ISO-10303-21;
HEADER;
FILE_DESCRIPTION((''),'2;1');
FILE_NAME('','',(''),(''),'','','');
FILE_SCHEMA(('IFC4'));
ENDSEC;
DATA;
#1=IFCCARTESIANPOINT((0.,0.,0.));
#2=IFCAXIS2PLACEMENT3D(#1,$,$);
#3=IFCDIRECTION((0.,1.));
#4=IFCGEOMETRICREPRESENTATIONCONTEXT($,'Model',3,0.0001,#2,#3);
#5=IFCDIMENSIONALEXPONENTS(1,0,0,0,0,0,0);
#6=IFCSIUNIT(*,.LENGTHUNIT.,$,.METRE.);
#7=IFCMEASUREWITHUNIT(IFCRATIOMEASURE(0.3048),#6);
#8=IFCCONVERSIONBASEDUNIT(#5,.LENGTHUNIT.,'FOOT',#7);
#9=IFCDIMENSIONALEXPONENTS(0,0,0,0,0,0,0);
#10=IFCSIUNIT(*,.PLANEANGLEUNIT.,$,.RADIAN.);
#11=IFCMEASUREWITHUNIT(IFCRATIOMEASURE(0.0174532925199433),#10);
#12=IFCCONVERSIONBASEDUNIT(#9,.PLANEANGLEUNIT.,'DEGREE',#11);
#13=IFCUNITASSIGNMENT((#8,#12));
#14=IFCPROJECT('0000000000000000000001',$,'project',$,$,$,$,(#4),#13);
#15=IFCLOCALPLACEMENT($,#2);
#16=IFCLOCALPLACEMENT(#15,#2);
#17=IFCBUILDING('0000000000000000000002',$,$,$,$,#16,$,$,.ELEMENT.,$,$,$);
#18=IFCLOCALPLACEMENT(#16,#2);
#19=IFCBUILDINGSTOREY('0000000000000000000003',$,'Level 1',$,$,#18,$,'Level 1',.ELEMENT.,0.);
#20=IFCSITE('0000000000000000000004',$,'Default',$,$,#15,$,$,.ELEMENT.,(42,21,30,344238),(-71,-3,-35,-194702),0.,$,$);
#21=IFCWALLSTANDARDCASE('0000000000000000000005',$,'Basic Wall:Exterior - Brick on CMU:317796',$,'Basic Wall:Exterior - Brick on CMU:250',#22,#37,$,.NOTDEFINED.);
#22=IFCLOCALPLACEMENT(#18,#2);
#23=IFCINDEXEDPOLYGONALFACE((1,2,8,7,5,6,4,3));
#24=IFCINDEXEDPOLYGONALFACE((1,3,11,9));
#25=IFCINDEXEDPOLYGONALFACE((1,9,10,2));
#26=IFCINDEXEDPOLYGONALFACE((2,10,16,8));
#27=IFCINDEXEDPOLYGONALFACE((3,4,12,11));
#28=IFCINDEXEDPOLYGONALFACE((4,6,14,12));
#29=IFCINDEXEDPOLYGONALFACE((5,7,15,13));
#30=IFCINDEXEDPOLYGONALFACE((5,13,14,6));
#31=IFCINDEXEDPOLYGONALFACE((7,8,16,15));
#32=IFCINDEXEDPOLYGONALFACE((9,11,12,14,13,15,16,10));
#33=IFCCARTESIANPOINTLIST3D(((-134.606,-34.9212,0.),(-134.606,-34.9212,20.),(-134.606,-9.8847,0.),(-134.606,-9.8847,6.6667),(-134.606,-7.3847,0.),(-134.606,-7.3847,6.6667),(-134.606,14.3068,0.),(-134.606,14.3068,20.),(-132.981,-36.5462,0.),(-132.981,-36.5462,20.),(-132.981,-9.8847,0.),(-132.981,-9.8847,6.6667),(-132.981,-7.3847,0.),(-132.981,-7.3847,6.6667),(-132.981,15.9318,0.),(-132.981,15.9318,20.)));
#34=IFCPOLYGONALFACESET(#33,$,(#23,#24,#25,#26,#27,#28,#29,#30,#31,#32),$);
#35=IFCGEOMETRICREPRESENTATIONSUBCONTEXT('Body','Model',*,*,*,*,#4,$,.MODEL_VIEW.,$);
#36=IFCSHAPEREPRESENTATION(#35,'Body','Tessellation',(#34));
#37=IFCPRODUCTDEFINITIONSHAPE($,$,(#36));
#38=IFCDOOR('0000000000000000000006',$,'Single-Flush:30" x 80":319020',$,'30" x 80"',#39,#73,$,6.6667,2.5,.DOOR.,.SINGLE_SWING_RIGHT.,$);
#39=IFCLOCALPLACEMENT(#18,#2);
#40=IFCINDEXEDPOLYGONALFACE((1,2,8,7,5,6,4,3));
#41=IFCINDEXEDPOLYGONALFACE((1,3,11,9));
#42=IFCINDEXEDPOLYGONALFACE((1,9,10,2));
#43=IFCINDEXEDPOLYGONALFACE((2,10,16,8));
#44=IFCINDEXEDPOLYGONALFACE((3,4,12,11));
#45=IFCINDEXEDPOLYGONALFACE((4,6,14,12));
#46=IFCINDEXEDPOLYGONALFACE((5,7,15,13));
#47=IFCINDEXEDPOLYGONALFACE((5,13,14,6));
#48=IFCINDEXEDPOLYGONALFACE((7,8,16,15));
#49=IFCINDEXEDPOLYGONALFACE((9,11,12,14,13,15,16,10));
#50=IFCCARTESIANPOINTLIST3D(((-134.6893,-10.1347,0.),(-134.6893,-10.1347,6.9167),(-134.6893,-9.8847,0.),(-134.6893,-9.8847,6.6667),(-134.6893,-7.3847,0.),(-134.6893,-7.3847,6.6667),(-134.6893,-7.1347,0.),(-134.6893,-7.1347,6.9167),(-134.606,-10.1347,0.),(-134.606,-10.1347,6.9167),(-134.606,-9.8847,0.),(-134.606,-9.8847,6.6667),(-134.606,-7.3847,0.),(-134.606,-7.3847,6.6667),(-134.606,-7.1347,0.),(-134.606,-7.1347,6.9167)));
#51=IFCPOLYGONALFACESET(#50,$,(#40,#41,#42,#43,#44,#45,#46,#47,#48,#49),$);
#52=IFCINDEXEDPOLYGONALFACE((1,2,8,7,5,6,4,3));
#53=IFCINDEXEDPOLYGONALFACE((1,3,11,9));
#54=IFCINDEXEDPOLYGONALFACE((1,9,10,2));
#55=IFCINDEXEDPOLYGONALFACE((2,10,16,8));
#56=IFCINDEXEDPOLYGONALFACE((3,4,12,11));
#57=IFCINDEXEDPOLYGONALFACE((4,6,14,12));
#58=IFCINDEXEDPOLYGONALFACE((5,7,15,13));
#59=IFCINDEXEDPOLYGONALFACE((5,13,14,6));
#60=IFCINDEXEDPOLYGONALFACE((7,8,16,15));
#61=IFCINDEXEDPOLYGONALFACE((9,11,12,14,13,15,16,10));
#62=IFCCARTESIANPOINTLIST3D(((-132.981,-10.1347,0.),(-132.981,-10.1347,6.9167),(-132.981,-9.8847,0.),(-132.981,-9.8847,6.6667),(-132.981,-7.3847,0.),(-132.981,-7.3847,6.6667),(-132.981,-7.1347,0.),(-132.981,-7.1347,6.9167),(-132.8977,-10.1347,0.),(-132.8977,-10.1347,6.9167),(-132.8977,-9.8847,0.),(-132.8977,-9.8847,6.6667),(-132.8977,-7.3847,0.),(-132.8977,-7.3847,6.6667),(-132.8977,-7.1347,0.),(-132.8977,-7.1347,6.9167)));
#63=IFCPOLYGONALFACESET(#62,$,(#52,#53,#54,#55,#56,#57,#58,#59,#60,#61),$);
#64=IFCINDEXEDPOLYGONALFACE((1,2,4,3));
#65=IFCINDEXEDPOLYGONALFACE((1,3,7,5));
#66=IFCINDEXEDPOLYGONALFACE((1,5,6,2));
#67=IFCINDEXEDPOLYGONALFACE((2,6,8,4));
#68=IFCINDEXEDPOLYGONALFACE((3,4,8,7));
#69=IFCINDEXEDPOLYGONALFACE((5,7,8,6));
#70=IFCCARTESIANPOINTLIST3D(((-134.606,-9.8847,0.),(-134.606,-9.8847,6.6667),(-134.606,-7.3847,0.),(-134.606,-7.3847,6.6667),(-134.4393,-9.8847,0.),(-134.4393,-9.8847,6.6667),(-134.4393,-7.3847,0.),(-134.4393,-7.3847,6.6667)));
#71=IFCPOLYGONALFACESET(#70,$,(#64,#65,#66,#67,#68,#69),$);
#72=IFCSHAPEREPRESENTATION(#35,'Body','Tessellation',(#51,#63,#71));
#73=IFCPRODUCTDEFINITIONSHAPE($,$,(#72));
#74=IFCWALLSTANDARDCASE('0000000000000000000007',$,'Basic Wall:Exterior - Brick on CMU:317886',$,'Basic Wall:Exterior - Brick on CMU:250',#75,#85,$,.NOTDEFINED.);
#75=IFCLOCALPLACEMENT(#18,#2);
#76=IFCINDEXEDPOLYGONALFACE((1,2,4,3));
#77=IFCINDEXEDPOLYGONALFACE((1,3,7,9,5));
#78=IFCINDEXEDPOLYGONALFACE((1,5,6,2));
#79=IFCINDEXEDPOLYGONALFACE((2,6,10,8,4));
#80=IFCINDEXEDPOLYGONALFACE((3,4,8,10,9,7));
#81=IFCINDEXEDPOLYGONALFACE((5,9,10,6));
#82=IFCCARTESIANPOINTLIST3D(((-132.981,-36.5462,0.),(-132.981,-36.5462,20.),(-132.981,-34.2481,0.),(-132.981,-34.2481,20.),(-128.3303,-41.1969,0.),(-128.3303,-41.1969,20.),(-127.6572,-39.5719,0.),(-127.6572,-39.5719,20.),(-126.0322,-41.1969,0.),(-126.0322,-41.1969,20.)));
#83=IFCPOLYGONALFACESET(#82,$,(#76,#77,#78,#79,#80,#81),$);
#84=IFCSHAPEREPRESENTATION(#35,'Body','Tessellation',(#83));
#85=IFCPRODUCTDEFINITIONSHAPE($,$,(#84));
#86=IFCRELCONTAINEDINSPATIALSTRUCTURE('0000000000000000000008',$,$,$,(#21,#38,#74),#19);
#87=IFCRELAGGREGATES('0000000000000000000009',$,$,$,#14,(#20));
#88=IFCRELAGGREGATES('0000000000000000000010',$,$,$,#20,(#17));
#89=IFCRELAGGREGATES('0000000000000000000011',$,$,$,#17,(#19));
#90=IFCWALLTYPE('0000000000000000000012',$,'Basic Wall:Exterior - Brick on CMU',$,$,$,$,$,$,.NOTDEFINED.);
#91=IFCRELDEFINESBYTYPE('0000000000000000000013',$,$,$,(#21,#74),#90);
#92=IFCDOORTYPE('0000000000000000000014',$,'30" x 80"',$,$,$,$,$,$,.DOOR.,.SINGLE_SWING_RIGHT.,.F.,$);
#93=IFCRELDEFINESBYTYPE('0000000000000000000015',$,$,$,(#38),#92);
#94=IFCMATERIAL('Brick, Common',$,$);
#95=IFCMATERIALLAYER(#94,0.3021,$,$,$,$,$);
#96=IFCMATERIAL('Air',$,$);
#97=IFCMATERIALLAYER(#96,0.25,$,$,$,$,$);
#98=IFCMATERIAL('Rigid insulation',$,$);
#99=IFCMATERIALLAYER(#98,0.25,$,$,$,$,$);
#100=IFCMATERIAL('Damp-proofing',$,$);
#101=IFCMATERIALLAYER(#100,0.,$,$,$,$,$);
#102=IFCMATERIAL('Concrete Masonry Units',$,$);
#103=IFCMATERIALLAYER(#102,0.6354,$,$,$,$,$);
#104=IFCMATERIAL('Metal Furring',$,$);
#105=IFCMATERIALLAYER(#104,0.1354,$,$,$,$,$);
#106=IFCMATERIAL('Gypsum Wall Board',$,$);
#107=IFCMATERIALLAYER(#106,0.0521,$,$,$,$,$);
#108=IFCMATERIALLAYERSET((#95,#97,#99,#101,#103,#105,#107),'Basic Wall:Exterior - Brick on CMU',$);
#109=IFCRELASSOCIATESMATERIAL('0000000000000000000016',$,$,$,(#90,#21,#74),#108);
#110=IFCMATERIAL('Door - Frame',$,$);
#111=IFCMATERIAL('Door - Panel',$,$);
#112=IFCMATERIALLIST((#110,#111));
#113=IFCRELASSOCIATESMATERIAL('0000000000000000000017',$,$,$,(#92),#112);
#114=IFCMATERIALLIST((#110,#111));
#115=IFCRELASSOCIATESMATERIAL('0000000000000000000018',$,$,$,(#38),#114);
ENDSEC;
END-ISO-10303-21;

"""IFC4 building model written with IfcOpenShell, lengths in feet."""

from ifc_helpers import new_model, entity, si_unit, converted_unit, direction, frame, frame_2d, origin, place, context, subcontext, project, spatial, polyline, rectangle, outline, extrude, source, transform, mapped, material, material_list, layer, layer_set, layer_usage, type_object, type_shapes, element, fill, save


model = new_model("IFC4")

# Units and contexts
model_context = context("Model", 3, precision=0.0001, world=origin(), true_north=direction((0.0, 1.0)))
body_context = subcontext(model_context, "Body", "Model", "MODEL_VIEW")
ifc_project = project(units=[converted_unit("LENGTHUNIT", "FOOT", entity("IfcRatioMeasure", 0.3048), si_unit("LENGTHUNIT", "METRE"), dimensions=[1, 0, 0, 0, 0, 0, 0]), converted_unit("PLANEANGLEUNIT", "DEGREE", entity("IfcRatioMeasure", 0.0174532925199433), si_unit("PLANEANGLEUNIT", "RADIAN"), dimensions=[0, 0, 0, 0, 0, 0, 0])], contexts=[model_context])

# Site, building, storey
site_placement = place(None, origin())
site = spatial("IfcSite", under=ifc_project, at=site_placement, Name="Default", CompositionType="ELEMENT", RefLatitude=(42, 21, 30, 344238), RefLongitude=(-71, -3, -35, -194702), RefElevation=0.0)
building_placement = place(site_placement, origin())
building = spatial("IfcBuilding", under=site, at=building_placement, CompositionType="ELEMENT")
storey_placement = place(building_placement, origin())
storey = spatial("IfcBuildingStorey", under=building, at=storey_placement, Name="Level 1", LongName="Level 1", CompositionType="ELEMENT", Elevation=0.0)

# Shared definitions
ifc_material_1 = material(Name="Brick, Common")
ifc_layer_1 = layer(ifc_material_1, 0.3021)
ifc_material_2 = material(Name="Air")
ifc_layer_2 = layer(ifc_material_2, 0.25)
ifc_material_3 = material(Name="Rigid insulation")
ifc_layer_3 = layer(ifc_material_3, 0.25)
ifc_material_4 = material(Name="Damp-proofing")
ifc_layer_4 = layer(ifc_material_4, 0.0)
ifc_material_5 = material(Name="Concrete Masonry Units")
ifc_layer_5 = layer(ifc_material_5, 0.6354)
ifc_material_6 = material(Name="Metal Furring")
ifc_layer_6 = layer(ifc_material_6, 0.1354)
ifc_material_7 = material(Name="Gypsum Wall Board")
ifc_layer_7 = layer(ifc_material_7, 0.0521)
ifc_layer_set = layer_set([ifc_layer_1, ifc_layer_2, ifc_layer_3, ifc_layer_4, ifc_layer_5, ifc_layer_6, ifc_layer_7], Name="Basic Wall:Exterior - Brick on CMU")
wall_type = type_object("IfcWallType", Name="Basic Wall:Exterior - Brick on CMU", PredefinedType="NOTDEFINED", material=ifc_layer_set)
ifc_material_8 = material(Name="Door - Frame")
ifc_material_9 = material(Name="Door - Panel")
ifc_material_list_1 = material_list([ifc_material_8, ifc_material_9])
door_type = type_object("IfcDoorType", Name="30\" x 80\"", OperationType="SINGLE_SWING_RIGHT", ParameterTakesPrecedence=False, PredefinedType="DOOR", material=ifc_material_list_1)
shared_shape_1 = source(origin(), body_context, "Body", "SweptSolid", [
    extrude(outline(polyline([(-1.5, -3.5208), (1.5, -3.5208), (1.5, 3.3958), (1.25, 3.3958), (1.25, -3.2708), (-1.25, -3.2708), (-1.25, 3.3958), (-1.5, 3.3958), (-1.5, -3.5208)])), frame((1.25, 1.625, 3.3958), z_axis=(0.0, 1.0, 0.0), x_axis=(1.0, 0.0, 0.0)), (0.0, 0.0, 1.0), 0.0833),
    extrude(outline(polyline([(-3.5208, -1.5), (3.3958, -1.5), (3.3958, -1.25), (-3.2708, -1.25), (-3.2708, 1.25), (3.3958, 1.25), (3.3958, 1.5), (-3.5208, 1.5), (-3.5208, -1.5)])), frame((1.25, -0.0833, 3.3958), z_axis=(0.0, 1.0, 0.0), x_axis=(0.0, 0.0, -1.0)), (0.0, 0.0, 1.0), 0.0833),
    extrude(rectangle(XDim=0.1667, YDim=2.5, at=frame_2d((0.0, 0.0), x_axis=(1.0, 0.0))), frame((1.25, 1.5417, 0.0), z_axis=(0.0, 0.0, 1.0), x_axis=(0.0, 1.0, 0.0)), (0.0, 0.0, 1.0), 6.6667),
])
type_shapes(door_type, [shared_shape_1])

# Wall, opening, door
ifc_layer_usage_1 = layer_usage(ifc_layer_set, "AXIS2", "NEGATIVE", 0.8125)
wall_1_placement = place(storey_placement, frame((-133.7935, 15.9318, 0.0), z_axis=(0.0, 0.0, 1.0), x_axis=(0.0, -1.0, 0.0)))
wall_1 = element("IfcWallStandardCase", 1, at=wall_1_placement, inside=storey, type_object=wall_type, material=ifc_layer_usage_1, Name="Basic Wall:Exterior - Brick on CMU:317796", ObjectType="Basic Wall:Exterior - Brick on CMU:250", PredefinedType="NOTDEFINED", context=body_context, shape_type="SweptSolid", body=[
    extrude(outline(polyline([(1.625, -0.8125), (50.853, -0.8125), (52.478, 0.8125), (50.1799, 0.8125), (0.0, 0.8125), (1.625, -0.8125)])), origin(), (0.0, 0.0, 1.0), 20.0),
])
opening_1_placement = place(wall_1_placement, frame((25.8165, 0.8125, 0.0)))
opening_1 = element("IfcOpeningElement", 2, at=opening_1_placement, cuts=wall_1, ObjectType="Opening", PredefinedType="OPENING", context=body_context, shape_type="SweptSolid", body=[
    extrude(rectangle(XDim=2.5, YDim=6.6667, at=frame_2d((3.3333, 1.25), x_axis=(0.0, 1.0))), frame((0.0, 0.0, 0.0), z_axis=(0.0, -1.0, 0.0), x_axis=(0.0, 0.0, 1.0)), (0.0, 0.0, 1.0), 1.625),
])
ifc_material_list_2 = material_list([ifc_material_8, ifc_material_9])
door_1_placement = place(opening_1_placement, frame((0.0, 0.0, 0.0), z_axis=(0.0, 0.0, 1.0), x_axis=(-1.0, 0.0, 0.0)))
door_1 = element("IfcDoor", 3, at=door_1_placement, inside=storey, type_object=door_type, material=ifc_material_list_2, Name="Single-Flush:30\" x 80\":319020", ObjectType="30\" x 80\"", OperationType="SINGLE_SWING_RIGHT", OverallHeight=6.6667, OverallWidth=2.5, PredefinedType="DOOR", context=body_context, shape_type="MappedRepresentation", body=[
    mapped(shared_shape_1, transform((0.0, 0.0, 0.0), scale=1.0)),
])
fill(opening_1, door_1)

# Wall
ifc_layer_usage_2 = layer_usage(ifc_layer_set, "AXIS2", "NEGATIVE", 0.8125)
wall_2_placement = place(storey_placement, frame((-133.5555, -34.8226, 0.0), z_axis=(0.0, 0.0, 1.0), x_axis=(0.707107, -0.707107, 0.0)))
element("IfcWallStandardCase", 4, at=wall_2_placement, inside=storey, type_object=wall_type, material=ifc_layer_usage_2, Name="Basic Wall:Exterior - Brick on CMU:317886", ObjectType="Basic Wall:Exterior - Brick on CMU:250", PredefinedType="NOTDEFINED", context=body_context, shape_type="SweptSolid", body=[
    extrude(outline(polyline([(8.2021, -0.8125), (9.8271, 0.8125), (7.529, 0.8125), (0.0, 0.8125), (1.625, -0.8125), (8.2021, -0.8125)])), origin(), (0.0, 0.0, 1.0), 20.0),
])

save(model, "model.ifc")
